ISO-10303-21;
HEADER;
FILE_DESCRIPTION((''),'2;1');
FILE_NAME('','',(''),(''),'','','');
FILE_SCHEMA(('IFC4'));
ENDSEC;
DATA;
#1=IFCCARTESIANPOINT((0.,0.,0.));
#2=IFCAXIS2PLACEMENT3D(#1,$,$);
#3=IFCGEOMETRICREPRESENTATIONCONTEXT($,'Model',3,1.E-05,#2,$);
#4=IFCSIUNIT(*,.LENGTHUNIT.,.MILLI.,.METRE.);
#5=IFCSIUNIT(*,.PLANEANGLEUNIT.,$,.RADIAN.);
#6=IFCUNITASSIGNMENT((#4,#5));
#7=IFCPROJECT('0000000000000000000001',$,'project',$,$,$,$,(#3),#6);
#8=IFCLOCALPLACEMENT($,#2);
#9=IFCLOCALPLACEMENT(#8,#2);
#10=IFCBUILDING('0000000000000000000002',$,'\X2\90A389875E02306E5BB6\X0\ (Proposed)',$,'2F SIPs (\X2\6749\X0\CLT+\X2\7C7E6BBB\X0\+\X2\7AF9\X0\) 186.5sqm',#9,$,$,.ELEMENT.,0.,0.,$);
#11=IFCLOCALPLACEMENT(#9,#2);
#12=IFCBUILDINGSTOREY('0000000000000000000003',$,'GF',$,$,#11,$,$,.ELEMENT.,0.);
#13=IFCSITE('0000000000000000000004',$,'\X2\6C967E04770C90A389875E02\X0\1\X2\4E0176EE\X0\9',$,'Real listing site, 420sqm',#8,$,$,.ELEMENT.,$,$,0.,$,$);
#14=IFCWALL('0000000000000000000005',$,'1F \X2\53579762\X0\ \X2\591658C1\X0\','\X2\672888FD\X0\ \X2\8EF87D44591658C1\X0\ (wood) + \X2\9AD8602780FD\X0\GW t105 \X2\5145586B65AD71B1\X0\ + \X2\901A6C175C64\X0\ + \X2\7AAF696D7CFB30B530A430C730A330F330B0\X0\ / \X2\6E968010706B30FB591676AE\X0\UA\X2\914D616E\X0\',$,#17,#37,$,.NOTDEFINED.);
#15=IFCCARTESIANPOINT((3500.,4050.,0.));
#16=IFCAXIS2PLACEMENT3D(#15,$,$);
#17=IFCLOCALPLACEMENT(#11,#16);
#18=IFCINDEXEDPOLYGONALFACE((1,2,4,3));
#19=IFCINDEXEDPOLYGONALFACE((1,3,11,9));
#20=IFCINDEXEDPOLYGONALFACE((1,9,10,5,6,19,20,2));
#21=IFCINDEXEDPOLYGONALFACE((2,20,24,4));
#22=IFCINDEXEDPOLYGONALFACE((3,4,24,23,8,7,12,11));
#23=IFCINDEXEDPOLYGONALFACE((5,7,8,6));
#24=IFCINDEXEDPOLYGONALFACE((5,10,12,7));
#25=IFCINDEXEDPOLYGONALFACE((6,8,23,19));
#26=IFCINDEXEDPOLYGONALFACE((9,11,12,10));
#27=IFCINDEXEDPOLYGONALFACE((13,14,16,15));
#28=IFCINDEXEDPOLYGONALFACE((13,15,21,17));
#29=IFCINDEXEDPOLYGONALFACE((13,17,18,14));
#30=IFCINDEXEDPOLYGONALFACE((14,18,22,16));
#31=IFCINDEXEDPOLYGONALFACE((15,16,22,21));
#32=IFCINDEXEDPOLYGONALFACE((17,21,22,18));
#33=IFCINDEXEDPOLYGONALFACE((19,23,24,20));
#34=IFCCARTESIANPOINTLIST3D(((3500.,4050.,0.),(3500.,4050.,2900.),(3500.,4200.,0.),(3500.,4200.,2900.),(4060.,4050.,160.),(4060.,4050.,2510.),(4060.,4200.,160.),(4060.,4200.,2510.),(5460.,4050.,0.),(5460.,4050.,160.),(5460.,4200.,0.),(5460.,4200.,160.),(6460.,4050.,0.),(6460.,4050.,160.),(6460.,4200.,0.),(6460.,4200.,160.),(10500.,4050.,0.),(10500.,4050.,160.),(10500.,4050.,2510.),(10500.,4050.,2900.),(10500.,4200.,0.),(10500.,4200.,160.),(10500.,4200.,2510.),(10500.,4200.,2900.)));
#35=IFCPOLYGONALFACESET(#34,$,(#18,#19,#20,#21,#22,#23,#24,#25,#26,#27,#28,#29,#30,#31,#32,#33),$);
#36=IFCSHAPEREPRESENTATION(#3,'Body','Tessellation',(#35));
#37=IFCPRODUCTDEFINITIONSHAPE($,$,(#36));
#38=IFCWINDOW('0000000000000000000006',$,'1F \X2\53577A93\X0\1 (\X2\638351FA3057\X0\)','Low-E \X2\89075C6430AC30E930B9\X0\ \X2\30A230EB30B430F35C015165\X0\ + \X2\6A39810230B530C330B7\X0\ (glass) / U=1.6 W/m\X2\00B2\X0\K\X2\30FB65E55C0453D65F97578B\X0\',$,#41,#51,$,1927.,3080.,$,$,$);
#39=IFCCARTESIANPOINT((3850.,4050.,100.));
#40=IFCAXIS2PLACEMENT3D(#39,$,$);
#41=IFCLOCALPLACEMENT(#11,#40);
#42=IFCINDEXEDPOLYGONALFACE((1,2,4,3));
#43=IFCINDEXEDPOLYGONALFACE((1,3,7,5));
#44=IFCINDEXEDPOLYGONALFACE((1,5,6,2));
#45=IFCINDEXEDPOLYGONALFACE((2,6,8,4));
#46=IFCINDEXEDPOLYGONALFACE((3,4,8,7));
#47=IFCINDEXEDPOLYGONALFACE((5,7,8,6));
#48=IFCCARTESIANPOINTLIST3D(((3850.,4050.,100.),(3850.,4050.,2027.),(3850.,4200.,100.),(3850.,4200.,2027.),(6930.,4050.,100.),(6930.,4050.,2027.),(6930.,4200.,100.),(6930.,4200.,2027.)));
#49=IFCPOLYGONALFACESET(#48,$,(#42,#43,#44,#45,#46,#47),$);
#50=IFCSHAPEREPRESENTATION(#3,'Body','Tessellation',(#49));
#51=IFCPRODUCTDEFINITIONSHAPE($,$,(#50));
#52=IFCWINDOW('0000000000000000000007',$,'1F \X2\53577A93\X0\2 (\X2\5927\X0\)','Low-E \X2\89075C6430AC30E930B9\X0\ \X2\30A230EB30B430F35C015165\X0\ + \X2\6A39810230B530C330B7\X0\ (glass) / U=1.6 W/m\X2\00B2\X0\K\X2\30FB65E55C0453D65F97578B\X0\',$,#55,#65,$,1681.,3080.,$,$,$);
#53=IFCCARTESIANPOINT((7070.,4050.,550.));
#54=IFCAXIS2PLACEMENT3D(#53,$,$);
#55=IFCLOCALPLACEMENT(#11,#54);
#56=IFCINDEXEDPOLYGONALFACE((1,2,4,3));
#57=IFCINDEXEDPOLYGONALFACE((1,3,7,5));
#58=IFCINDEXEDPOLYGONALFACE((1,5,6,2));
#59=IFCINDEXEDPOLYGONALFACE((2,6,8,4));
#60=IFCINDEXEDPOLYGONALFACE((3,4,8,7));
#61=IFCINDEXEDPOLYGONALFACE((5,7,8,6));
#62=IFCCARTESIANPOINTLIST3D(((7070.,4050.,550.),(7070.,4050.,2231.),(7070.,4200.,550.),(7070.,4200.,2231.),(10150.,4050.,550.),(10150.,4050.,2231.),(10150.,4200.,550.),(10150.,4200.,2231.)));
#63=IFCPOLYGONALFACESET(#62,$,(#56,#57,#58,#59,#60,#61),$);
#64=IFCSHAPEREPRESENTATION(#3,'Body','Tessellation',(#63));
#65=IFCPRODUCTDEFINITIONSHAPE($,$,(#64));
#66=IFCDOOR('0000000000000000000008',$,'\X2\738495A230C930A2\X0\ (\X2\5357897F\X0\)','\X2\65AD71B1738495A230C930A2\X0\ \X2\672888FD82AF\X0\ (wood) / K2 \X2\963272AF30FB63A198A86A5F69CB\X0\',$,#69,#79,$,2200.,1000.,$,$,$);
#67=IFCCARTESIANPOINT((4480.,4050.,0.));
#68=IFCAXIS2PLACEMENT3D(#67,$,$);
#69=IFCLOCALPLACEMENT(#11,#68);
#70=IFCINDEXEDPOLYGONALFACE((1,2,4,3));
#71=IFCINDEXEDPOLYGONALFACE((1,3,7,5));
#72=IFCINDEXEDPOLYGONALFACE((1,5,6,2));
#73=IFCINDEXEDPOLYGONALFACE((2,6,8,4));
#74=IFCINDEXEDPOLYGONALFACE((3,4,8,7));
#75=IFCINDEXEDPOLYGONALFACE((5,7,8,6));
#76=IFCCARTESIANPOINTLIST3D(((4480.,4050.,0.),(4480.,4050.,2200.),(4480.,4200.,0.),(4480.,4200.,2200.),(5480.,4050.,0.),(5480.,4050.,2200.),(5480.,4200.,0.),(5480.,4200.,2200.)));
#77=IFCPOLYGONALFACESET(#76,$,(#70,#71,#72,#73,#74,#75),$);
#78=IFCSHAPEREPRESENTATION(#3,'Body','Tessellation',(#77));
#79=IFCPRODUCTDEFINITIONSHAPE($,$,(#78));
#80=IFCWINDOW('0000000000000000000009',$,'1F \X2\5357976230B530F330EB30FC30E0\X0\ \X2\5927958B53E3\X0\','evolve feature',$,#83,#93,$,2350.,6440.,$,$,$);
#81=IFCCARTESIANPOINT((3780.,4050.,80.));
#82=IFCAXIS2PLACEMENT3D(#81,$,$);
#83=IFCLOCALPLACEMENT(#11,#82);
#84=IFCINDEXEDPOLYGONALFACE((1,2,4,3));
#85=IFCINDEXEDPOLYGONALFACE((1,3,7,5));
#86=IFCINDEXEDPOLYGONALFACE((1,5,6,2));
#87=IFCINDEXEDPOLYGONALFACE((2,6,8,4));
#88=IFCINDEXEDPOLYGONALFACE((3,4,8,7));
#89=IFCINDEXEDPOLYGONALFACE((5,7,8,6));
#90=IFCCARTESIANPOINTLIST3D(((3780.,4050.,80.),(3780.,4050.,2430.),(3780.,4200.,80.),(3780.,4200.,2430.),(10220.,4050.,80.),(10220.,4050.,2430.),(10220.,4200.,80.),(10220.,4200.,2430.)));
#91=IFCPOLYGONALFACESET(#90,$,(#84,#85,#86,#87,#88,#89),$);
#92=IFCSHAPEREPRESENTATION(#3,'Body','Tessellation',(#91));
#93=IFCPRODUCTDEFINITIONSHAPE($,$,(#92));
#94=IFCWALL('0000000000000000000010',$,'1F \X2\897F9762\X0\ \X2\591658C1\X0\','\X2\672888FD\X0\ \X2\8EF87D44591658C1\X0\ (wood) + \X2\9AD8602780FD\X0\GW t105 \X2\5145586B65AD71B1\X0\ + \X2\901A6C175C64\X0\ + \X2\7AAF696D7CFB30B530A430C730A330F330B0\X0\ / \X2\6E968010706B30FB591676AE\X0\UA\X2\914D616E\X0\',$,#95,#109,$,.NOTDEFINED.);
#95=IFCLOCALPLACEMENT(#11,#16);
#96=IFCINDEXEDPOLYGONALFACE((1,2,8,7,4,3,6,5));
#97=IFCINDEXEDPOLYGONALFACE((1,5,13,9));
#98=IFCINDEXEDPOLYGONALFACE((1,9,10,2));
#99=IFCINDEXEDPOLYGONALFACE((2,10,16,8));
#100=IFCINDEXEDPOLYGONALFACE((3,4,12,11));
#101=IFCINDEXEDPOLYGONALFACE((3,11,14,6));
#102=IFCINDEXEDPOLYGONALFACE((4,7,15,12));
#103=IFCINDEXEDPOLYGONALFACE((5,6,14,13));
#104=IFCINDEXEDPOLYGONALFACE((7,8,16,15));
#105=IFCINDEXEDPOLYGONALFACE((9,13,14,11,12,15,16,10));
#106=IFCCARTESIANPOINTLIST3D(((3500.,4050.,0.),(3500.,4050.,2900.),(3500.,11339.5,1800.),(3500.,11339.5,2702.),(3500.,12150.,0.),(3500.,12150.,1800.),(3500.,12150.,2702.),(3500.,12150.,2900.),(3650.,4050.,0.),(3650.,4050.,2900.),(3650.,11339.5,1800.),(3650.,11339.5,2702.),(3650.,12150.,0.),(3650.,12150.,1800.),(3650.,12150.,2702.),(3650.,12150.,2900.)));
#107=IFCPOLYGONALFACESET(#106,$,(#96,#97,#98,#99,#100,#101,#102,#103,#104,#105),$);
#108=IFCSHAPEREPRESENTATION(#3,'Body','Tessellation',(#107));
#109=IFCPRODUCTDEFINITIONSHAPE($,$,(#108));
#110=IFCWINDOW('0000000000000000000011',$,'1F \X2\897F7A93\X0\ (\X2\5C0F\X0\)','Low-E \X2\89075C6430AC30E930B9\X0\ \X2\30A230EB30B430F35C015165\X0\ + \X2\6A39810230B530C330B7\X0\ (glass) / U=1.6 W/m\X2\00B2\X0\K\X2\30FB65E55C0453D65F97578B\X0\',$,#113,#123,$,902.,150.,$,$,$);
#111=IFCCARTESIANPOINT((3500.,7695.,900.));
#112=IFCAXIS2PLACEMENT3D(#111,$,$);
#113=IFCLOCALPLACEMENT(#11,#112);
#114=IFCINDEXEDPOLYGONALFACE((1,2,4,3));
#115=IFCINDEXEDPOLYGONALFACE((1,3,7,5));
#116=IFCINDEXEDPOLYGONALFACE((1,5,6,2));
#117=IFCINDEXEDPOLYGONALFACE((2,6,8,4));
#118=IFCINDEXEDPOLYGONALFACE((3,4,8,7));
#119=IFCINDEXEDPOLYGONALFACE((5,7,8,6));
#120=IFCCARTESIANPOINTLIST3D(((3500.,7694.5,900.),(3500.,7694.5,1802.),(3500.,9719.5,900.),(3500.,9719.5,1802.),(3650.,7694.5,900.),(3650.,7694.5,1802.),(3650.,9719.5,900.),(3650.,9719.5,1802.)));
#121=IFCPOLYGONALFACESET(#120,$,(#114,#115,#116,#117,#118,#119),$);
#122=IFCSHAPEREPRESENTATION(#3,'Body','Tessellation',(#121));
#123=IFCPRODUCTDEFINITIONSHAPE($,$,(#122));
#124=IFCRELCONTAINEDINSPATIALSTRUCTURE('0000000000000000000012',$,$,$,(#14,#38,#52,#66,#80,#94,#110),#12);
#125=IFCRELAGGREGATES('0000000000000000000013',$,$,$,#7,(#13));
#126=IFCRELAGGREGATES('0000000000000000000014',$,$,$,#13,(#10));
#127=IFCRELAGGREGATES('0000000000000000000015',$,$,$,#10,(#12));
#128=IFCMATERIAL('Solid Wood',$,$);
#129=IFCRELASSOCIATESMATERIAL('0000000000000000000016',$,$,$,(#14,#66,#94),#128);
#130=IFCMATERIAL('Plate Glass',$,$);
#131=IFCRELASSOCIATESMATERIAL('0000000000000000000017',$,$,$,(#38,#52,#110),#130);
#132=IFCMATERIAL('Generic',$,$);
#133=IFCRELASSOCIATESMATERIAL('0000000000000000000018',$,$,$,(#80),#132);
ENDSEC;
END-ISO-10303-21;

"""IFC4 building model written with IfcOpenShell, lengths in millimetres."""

from ifc_helpers import new_model, si_unit, frame, frame_2d, origin, place, context, project, spatial, rectangle, extrude, material, element, fill, save


model = new_model("IFC4")

# Units and contexts
model_context = context("Model", 3, precision=1e-05, world=origin())
ifc_project = project(units=[si_unit("LENGTHUNIT", "METRE", prefix="MILLI"), si_unit("PLANEANGLEUNIT", "RADIAN")], contexts=[model_context])

# Site, building, storey
site_placement = place(None, origin())
site = spatial("IfcSite", under=ifc_project, at=site_placement, Name="沖縄県那覇市1丁目9", ObjectType="Real listing site, 420sqm", CompositionType="ELEMENT", RefElevation=0.0)
building_placement = place(site_placement, origin())
building = spatial("IfcBuilding", under=site, at=building_placement, Name="那覇市の家 (Proposed)", ObjectType="2F SIPs (杉CLT+籾殻+竹) 186.5sqm", CompositionType="ELEMENT", ElevationOfRefHeight=0.0, ElevationOfTerrain=0.0)
storey_placement = place(building_placement, origin())
storey = spatial("IfcBuildingStorey", under=building, at=storey_placement, Name="GF", CompositionType="ELEMENT", Elevation=0.0)

# Shared definitions
ifc_material_1 = material(Name="Solid Wood")
ifc_material_2 = material(Name="Generic")

# Wall, openings, windows, door
wall_1_placement = place(storey_placement, frame((3500.0, 4050.0, 0.0)))
wall_1 = element("IfcWall", 1, at=wall_1_placement, inside=storey, material=ifc_material_1, Name="1F 南面 外壁", Description="木製 軸組外壁 (wood) + 高性能GW t105 充填断熱 + 通気層 + 窯業系サイディング / 準耐火・外皮UA配慮", PredefinedType="NOTDEFINED", context=model_context, shape_type="SweptSolid", body=[
    extrude(rectangle(XDim=7000.0, YDim=150.0, at=frame_2d((3500.0, 75.0))), frame((3500.0, 4050.0, 0.0)), (0.0, 0.0, 1.0), 2900.0),
])
opening_1_placement = place(storey_placement, frame((3850.0, 4050.0, 100.0)))
opening_1 = element("IfcOpeningElement", 2, at=opening_1_placement, cuts=wall_1, PredefinedType="NOTDEFINED", context=model_context, shape_type="SweptSolid", body=[
    extrude(rectangle(XDim=3080.0, YDim=150.0, at=frame_2d((1540.0, 75.0))), frame((3850.0, 4050.0, 100.0)), (0.0, 0.0, 1.0), 1927.0),
])
opening_2_placement = place(storey_placement, frame((7070.0, 4050.0, 550.0)))
opening_2 = element("IfcOpeningElement", 3, at=opening_2_placement, cuts=wall_1, PredefinedType="NOTDEFINED", context=model_context, shape_type="SweptSolid", body=[
    extrude(rectangle(XDim=3080.0, YDim=150.0, at=frame_2d((1540.0, 75.0))), frame((7070.0, 4050.0, 550.0)), (0.0, 0.0, 1.0), 1681.0),
])
opening_3_placement = place(storey_placement, frame((4480.0, 4050.0, 0.0)))
opening_3 = element("IfcOpeningElement", 4, at=opening_3_placement, cuts=wall_1, PredefinedType="NOTDEFINED", context=model_context, shape_type="SweptSolid", body=[
    extrude(rectangle(XDim=1000.0, YDim=150.0, at=frame_2d((500.0, 75.0))), frame((4480.0, 4050.0, 0.0)), (0.0, 0.0, 1.0), 2200.0),
])
opening_4_placement = place(storey_placement, frame((3780.0, 4050.0, 80.0)))
opening_4 = element("IfcOpeningElement", 5, at=opening_4_placement, cuts=wall_1, PredefinedType="NOTDEFINED", context=model_context, shape_type="SweptSolid", body=[
    extrude(rectangle(XDim=6440.0, YDim=150.0, at=frame_2d((3220.0, 75.0))), frame((3780.0, 4050.0, 80.0)), (0.0, 0.0, 1.0), 2350.0),
])
ifc_material_3 = material(Name="Plate Glass")
window_1_placement = place(storey_placement, frame((3850.0, 4050.0, 100.0)))
window_1 = element("IfcWindow", 6, at=window_1_placement, inside=storey, material=ifc_material_3, Name="1F 南窓1 (掃出し)", Description="Low-E 複層ガラス アルゴン封入 + 樹脂サッシ (glass) / U=1.6 W/m²K・日射取得型", OverallHeight=1927.0, OverallWidth=3080.0, context=model_context, shape_type="SweptSolid", body=[
    extrude(rectangle(XDim=3080.0, YDim=150.0, at=frame_2d((1540.0, 75.0))), frame((3850.0, 4050.0, 100.0)), (0.0, 0.0, 1.0), 1927.0),
])
fill(opening_1, window_1)
window_2_placement = place(storey_placement, frame((7070.0, 4050.0, 550.0)))
window_2 = element("IfcWindow", 7, at=window_2_placement, inside=storey, material=ifc_material_3, Name="1F 南窓2 (大)", Description="Low-E 複層ガラス アルゴン封入 + 樹脂サッシ (glass) / U=1.6 W/m²K・日射取得型", OverallHeight=1681.0, OverallWidth=3080.0, context=model_context, shape_type="SweptSolid", body=[
    extrude(rectangle(XDim=3080.0, YDim=150.0, at=frame_2d((1540.0, 75.0))), frame((7070.0, 4050.0, 550.0)), (0.0, 0.0, 1.0), 1681.0),
])
fill(opening_2, window_2)
door_placement = place(storey_placement, frame((4480.0, 4050.0, 0.0)))
door = element("IfcDoor", 8, at=door_placement, inside=storey, material=ifc_material_1, Name="玄関ドア (南西)", Description="断熱玄関ドア 木製芯 (wood) / K2 防犯・採風機構", OverallHeight=2200.0, OverallWidth=1000.0, context=model_context, shape_type="SweptSolid", body=[
    extrude(rectangle(XDim=1000.0, YDim=150.0, at=frame_2d((500.0, 75.0))), frame((4480.0, 4050.0, 0.0)), (0.0, 0.0, 1.0), 2200.0),
])
fill(opening_3, door)
window_3_placement = place(storey_placement, frame((3780.0, 4050.0, 80.0)))
window_3 = element("IfcWindow", 9, at=window_3_placement, inside=storey, material=ifc_material_2, Name="1F 南面サンルーム 大開口", Description="evolve feature", OverallHeight=2350.0, OverallWidth=6440.0, context=model_context, shape_type="SweptSolid", body=[
    extrude(rectangle(XDim=6440.0, YDim=150.0, at=frame_2d((3220.0, 75.0))), frame((3780.0, 4050.0, 80.0)), (0.0, 0.0, 1.0), 2350.0),
])
fill(opening_4, window_3)

# Wall, opening, window
wall_2_placement = place(storey_placement, frame((3500.0, 4050.0, 0.0)))
wall_2 = element("IfcWall", 10, at=wall_2_placement, inside=storey, material=ifc_material_1, Name="1F 西面 外壁", Description="木製 軸組外壁 (wood) + 高性能GW t105 充填断熱 + 通気層 + 窯業系サイディング / 準耐火・外皮UA配慮", PredefinedType="NOTDEFINED", context=model_context, shape_type="SweptSolid", body=[
    extrude(rectangle(XDim=150.0, YDim=8100.0, at=frame_2d((75.0, 4050.0))), frame((3500.0, 4050.0, 0.0)), (0.0, 0.0, 1.0), 2900.0),
])
opening_5_placement = place(storey_placement, frame((3500.0, 7695.0, 900.0)))
opening_5 = element("IfcOpeningElement", 11, at=opening_5_placement, cuts=wall_2, PredefinedType="NOTDEFINED", context=model_context, shape_type="SweptSolid", body=[
    extrude(rectangle(XDim=150.0, YDim=2025.0, at=frame_2d((75.0, 1012.0))), frame((3500.0, 7695.0, 900.0)), (0.0, 0.0, 1.0), 902.0),
])
window_4_placement = place(storey_placement, frame((3500.0, 7695.0, 900.0)))
window_4 = element("IfcWindow", 12, at=window_4_placement, inside=storey, material=ifc_material_3, Name="1F 西窓 (小)", Description="Low-E 複層ガラス アルゴン封入 + 樹脂サッシ (glass) / U=1.6 W/m²K・日射取得型", OverallHeight=902.0, OverallWidth=150.0, context=model_context, shape_type="SweptSolid", body=[
    extrude(rectangle(XDim=150.0, YDim=2025.0, at=frame_2d((75.0, 1012.0))), frame((3500.0, 7695.0, 900.0)), (0.0, 0.0, 1.0), 902.0),
])
fill(opening_5, window_4)

save(model, "model.ifc")
